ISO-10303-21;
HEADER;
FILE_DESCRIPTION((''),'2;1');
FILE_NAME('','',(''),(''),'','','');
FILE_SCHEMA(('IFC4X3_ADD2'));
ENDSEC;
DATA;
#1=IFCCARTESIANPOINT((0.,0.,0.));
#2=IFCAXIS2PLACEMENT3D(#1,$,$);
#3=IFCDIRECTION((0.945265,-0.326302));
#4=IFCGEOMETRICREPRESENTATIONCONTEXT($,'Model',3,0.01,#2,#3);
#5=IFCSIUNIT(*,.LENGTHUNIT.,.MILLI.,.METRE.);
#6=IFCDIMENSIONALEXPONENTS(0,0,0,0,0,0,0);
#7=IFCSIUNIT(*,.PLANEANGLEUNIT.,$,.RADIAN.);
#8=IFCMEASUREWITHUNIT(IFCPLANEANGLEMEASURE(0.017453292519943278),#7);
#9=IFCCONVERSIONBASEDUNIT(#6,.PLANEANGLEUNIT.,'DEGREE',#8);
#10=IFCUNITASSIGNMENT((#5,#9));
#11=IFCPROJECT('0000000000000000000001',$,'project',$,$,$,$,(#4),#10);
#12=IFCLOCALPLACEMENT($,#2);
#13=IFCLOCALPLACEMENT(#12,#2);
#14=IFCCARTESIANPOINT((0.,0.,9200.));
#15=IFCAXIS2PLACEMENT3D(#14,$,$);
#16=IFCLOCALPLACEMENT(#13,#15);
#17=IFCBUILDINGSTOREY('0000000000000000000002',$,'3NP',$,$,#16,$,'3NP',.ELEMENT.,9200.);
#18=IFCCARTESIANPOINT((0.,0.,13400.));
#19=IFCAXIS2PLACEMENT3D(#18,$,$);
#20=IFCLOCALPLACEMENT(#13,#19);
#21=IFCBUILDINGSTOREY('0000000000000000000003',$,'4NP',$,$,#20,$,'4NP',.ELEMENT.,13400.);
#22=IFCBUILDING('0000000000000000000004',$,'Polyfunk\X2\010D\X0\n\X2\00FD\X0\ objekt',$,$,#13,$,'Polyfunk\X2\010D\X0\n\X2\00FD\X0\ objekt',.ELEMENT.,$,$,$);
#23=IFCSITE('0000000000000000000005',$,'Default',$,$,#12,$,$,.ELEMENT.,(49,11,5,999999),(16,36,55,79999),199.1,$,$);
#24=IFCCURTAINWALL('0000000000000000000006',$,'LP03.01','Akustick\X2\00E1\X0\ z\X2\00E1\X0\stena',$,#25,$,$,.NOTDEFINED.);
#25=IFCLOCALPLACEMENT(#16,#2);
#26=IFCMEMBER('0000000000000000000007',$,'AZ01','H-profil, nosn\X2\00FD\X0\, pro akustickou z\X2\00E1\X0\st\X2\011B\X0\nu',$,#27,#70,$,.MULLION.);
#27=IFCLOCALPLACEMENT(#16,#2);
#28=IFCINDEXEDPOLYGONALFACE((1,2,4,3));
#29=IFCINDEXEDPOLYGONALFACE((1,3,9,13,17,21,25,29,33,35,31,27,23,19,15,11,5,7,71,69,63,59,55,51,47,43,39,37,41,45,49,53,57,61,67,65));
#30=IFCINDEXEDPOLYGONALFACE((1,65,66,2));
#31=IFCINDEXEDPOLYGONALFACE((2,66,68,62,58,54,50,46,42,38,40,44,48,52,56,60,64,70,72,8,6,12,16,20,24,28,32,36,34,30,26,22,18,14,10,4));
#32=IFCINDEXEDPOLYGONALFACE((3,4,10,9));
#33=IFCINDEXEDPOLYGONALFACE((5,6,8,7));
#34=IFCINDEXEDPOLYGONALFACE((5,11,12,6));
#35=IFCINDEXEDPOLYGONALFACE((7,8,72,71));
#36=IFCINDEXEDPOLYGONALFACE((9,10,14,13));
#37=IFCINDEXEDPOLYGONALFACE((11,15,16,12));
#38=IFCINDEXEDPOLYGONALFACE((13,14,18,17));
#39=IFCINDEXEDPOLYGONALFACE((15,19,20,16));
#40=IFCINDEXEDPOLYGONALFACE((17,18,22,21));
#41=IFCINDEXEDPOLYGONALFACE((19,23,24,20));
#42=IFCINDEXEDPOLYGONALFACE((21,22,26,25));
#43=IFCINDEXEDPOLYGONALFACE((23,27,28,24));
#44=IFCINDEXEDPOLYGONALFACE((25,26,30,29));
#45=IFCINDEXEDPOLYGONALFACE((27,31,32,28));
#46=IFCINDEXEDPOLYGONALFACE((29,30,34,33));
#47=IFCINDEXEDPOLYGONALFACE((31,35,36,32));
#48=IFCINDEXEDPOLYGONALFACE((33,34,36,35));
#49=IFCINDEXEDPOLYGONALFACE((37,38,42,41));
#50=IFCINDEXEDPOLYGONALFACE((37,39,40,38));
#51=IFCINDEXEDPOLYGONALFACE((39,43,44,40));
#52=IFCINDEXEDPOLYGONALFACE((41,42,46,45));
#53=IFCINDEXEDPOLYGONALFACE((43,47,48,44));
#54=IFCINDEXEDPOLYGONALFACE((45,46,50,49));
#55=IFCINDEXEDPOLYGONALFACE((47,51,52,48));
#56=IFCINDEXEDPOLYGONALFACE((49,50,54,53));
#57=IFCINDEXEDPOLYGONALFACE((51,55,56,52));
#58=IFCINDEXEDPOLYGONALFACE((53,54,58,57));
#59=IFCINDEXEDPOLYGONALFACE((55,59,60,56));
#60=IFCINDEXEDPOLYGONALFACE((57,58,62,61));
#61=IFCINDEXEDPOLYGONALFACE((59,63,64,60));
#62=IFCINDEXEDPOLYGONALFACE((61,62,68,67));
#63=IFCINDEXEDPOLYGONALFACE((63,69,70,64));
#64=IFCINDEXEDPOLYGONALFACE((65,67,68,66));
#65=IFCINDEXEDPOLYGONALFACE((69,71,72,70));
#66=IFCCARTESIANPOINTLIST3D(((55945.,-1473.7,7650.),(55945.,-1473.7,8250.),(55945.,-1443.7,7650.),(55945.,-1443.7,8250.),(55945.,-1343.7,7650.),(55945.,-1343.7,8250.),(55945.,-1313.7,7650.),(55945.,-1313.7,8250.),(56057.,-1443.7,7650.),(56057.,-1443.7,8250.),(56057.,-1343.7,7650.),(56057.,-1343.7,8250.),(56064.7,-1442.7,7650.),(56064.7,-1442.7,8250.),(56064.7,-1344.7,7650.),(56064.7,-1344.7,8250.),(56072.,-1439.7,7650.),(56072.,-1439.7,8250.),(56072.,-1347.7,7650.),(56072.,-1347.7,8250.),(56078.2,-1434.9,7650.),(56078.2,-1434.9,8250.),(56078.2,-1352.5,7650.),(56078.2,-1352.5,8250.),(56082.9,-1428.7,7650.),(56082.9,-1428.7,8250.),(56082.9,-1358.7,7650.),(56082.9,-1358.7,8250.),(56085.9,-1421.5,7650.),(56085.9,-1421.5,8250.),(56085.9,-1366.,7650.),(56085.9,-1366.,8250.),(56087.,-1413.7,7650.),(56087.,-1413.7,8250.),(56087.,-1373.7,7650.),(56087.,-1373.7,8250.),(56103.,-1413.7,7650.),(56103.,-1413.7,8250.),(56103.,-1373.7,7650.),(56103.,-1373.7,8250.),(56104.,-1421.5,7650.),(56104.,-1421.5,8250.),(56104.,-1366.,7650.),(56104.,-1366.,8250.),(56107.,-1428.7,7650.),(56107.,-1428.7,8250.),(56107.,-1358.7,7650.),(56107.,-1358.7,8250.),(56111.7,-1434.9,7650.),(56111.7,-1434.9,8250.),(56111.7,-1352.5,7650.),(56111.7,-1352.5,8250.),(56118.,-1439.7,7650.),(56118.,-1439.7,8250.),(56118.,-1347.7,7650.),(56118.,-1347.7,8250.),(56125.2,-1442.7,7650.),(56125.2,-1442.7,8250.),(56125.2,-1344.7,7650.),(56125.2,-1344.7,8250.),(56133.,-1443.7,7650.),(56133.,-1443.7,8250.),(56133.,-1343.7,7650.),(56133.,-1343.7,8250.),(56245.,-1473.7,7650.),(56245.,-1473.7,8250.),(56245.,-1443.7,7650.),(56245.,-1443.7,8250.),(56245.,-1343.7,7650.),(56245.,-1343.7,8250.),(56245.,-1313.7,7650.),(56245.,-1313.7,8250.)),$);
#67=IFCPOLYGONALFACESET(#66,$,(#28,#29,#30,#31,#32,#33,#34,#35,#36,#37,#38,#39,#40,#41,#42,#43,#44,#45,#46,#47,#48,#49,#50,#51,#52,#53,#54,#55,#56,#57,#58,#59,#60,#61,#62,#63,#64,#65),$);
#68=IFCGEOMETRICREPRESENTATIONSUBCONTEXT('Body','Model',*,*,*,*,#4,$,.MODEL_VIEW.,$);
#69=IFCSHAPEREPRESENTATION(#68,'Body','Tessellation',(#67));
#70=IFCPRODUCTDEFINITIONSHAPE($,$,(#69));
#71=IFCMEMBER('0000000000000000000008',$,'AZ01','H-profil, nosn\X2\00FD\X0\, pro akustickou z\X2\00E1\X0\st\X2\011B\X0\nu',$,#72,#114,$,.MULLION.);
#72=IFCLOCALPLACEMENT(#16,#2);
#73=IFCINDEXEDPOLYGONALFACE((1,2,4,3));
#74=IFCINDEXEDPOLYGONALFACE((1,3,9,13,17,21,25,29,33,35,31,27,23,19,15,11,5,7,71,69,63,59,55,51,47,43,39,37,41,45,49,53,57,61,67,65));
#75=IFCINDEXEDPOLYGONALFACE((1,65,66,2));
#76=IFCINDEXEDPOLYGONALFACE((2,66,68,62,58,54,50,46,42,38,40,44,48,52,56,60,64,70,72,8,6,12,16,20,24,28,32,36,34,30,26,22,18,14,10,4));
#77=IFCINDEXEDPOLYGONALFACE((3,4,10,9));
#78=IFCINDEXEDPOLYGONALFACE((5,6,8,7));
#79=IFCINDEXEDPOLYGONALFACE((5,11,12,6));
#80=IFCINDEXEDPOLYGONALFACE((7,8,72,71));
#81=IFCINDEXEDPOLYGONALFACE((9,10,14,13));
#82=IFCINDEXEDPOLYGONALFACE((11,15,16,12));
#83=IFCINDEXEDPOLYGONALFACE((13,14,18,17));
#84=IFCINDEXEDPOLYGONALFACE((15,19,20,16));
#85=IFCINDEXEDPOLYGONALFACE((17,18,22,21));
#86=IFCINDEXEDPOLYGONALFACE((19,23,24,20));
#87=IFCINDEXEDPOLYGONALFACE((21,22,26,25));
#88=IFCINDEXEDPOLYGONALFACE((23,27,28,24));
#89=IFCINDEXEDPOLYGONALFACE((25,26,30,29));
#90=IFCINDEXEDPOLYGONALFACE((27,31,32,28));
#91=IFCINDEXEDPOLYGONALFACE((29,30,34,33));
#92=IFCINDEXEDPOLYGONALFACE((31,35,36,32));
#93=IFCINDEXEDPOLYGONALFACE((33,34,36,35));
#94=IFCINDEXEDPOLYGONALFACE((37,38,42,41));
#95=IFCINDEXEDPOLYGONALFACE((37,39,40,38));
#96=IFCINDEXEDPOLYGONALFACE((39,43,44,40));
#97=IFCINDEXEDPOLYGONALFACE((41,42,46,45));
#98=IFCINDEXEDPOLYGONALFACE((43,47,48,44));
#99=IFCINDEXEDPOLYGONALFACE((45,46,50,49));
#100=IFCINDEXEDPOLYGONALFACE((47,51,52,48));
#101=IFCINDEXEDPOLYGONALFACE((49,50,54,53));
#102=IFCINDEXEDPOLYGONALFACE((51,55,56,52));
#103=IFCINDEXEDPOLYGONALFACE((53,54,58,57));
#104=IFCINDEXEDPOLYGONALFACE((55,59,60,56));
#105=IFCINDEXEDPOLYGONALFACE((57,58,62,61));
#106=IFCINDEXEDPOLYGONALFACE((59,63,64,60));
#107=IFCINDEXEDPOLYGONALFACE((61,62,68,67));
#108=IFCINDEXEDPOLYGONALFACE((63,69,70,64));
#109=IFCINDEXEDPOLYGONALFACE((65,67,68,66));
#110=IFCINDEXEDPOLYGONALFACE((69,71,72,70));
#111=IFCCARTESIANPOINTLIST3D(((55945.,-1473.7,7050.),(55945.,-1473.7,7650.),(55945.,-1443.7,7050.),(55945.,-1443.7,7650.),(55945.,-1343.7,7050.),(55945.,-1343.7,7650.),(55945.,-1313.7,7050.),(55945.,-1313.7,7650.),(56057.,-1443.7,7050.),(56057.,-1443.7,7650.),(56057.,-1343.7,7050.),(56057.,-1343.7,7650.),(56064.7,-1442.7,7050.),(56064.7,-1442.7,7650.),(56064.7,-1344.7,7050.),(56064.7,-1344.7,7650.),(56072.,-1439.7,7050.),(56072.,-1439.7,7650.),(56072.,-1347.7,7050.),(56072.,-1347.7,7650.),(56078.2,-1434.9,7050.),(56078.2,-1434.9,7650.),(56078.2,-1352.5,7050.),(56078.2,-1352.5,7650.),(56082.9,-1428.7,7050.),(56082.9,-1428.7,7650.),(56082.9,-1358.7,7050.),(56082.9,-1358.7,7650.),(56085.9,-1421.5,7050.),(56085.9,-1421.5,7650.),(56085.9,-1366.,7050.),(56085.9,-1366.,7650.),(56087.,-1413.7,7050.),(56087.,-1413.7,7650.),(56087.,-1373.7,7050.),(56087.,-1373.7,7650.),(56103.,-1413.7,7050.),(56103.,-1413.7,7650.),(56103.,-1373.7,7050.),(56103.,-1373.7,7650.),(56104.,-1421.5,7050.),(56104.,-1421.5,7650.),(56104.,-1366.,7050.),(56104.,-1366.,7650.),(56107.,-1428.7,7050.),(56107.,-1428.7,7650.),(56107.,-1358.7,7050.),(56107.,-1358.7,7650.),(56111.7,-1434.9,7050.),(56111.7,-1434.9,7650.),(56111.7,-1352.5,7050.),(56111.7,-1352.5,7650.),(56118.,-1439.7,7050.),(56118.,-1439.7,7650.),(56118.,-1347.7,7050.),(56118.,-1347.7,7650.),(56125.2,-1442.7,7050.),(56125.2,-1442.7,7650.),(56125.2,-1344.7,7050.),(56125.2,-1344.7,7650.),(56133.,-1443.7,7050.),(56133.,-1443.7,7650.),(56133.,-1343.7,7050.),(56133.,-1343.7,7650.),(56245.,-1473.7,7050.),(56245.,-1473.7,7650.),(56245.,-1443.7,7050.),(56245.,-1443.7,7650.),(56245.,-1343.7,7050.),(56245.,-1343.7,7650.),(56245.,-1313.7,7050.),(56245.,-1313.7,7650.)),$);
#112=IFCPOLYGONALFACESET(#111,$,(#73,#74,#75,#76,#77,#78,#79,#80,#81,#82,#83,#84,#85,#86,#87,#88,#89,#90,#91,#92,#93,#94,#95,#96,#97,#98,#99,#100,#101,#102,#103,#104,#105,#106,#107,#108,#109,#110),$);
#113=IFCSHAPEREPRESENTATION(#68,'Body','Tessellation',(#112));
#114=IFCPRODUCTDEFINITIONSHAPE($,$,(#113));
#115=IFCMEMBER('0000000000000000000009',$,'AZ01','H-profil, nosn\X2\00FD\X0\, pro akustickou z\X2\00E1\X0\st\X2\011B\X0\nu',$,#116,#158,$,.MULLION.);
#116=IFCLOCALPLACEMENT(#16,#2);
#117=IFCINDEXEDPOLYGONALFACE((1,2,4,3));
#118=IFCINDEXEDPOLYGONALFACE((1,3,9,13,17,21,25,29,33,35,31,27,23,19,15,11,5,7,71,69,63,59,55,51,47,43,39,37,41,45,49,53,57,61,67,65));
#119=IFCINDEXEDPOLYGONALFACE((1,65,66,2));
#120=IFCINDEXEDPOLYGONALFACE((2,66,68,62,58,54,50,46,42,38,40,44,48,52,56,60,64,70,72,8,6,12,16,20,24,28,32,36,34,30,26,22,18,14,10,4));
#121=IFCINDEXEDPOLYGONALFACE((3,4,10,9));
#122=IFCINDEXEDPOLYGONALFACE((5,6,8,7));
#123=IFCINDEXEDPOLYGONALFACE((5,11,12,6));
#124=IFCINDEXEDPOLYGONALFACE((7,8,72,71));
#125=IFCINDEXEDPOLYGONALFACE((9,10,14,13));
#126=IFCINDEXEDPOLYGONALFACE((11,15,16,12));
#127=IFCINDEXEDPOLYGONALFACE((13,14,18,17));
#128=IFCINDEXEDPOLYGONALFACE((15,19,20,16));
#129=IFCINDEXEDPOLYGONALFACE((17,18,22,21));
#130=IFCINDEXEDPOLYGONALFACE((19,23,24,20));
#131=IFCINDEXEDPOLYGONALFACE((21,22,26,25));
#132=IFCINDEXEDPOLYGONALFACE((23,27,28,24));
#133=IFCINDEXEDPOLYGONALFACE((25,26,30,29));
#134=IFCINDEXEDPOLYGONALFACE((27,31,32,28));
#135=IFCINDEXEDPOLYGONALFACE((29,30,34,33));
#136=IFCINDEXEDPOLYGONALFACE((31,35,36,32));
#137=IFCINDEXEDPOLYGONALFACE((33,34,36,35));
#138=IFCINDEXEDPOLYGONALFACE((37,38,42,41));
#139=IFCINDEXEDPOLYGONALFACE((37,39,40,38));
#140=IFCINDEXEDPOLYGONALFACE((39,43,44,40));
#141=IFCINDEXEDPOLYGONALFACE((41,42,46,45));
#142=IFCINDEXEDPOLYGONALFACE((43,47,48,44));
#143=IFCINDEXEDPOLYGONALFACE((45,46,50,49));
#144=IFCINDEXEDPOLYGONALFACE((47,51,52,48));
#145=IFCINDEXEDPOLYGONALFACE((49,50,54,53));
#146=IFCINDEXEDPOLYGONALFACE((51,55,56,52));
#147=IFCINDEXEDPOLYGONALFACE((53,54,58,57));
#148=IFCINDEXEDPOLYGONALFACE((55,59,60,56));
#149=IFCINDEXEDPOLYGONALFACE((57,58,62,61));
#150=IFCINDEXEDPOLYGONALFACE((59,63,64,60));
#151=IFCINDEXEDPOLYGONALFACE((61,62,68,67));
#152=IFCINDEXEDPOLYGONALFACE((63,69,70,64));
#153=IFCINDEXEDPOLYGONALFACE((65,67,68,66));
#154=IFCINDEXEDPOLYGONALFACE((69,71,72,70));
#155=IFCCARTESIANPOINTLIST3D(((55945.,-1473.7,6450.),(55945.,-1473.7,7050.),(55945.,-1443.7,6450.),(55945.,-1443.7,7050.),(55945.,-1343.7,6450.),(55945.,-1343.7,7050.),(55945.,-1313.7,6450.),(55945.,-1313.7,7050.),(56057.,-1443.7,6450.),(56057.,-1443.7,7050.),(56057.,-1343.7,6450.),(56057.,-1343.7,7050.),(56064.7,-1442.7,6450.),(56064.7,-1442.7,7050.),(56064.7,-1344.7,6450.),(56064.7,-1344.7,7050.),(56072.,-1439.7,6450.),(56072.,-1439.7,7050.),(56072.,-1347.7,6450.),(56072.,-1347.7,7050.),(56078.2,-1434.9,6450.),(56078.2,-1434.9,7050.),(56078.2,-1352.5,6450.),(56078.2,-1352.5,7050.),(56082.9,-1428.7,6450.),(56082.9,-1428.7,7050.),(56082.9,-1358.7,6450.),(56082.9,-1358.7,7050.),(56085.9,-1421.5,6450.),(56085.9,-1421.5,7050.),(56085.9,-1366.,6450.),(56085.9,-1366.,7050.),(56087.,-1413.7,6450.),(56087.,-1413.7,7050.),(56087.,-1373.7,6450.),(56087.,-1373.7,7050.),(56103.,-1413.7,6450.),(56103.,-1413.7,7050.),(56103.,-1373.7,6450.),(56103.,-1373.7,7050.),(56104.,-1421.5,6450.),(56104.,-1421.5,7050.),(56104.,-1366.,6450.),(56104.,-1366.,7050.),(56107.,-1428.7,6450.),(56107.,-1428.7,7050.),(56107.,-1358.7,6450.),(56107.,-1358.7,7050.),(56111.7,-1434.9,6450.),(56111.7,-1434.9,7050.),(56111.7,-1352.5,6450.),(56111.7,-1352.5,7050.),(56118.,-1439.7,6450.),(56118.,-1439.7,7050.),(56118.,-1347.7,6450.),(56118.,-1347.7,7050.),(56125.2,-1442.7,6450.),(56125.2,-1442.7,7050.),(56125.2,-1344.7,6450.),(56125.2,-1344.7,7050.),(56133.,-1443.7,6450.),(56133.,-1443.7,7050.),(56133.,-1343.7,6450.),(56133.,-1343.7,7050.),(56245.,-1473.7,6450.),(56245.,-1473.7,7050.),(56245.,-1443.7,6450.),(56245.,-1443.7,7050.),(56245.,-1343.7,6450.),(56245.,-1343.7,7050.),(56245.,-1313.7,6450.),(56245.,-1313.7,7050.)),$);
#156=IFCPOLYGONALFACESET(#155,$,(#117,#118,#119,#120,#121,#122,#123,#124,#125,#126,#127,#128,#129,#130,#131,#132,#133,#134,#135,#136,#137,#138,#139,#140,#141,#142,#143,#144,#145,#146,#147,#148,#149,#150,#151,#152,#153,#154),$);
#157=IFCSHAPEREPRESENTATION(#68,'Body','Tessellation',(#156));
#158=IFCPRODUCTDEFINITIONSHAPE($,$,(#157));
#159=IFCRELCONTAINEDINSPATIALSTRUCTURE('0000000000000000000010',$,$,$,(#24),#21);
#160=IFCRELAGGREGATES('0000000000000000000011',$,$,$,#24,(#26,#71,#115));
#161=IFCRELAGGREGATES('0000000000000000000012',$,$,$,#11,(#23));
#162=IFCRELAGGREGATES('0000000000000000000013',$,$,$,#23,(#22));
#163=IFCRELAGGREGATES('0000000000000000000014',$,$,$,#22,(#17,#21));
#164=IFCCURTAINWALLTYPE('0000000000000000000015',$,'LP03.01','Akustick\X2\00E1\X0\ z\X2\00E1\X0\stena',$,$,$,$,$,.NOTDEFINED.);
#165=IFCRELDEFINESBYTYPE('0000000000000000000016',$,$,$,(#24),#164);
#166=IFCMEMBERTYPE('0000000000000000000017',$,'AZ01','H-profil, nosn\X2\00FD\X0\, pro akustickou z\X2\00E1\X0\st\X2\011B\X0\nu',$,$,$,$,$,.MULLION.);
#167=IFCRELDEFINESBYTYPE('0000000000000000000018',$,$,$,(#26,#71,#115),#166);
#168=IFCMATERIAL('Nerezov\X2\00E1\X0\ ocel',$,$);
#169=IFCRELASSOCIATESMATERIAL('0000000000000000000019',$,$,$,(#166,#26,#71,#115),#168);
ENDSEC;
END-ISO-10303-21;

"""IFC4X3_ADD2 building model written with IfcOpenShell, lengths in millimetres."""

from ifc_helpers import new_model, entity, si_unit, converted_unit, direction, frame, frame_2d, origin, place, context, subcontext, project, spatial, polyline, circle_curve, parameter, trimmed, segment, composite_curve, outline, extrude, source, transform, mapped, material, material_profile, profile_set, profile_usage, type_object, element, aggregate, save


model = new_model("IFC4X3_ADD2")

# Units and contexts
model_context = context("Model", 3, precision=0.01, world=origin(), true_north=direction((0.945265, -0.326302)))
body_context = subcontext(model_context, "Body", "Model", "MODEL_VIEW")
ifc_project = project(units=[si_unit("LENGTHUNIT", "METRE", prefix="MILLI"), converted_unit("PLANEANGLEUNIT", "DEGREE", entity("IfcPlaneAngleMeasure", 0.017453292519943278), si_unit("PLANEANGLEUNIT", "RADIAN"), dimensions=[0, 0, 0, 0, 0, 0, 0])], contexts=[model_context])

# Site, building, storey
site_placement = place(None, origin())
site = spatial("IfcSite", under=ifc_project, at=site_placement, Name="Default", CompositionType="ELEMENT", RefLatitude=(49, 11, 5, 999999), RefLongitude=(16, 36, 55, 79999), RefElevation=199.1)
building_placement = place(site_placement, origin())
building = spatial("IfcBuilding", under=site, at=building_placement, Name="Polyfunkčný objekt", LongName="Polyfunkčný objekt", CompositionType="ELEMENT")
storey_1_placement = place(building_placement, frame((0.0, 0.0, 9200.0)))
storey_1 = spatial("IfcBuildingStorey", under=building, at=storey_1_placement, Name="3NP", LongName="3NP", CompositionType="ELEMENT", Elevation=9200.0)

# Shared definitions
storey_2_placement = place(building_placement, frame((0.0, 0.0, 13400.0)))
storey_2 = spatial("IfcBuildingStorey", under=building, at=storey_2_placement, Name="4NP", LongName="4NP", CompositionType="ELEMENT", Elevation=13400.0)

# Curtain wall, members
curtain_wall_type_1 = type_object("IfcCurtainWallType", Name="LP03.01", Description="Akustická zástena", PredefinedType="NOTDEFINED")
curtain_wall_1_placement = place(storey_2_placement, frame((0.0, 0.0, -13400.0)))
curtain_wall_1 = element("IfcCurtainWall", 1, at=curtain_wall_1_placement, inside=storey_2, type_object=curtain_wall_type_1, Name="LP03.01", Description="Akustická zástena", PredefinedType="NOTDEFINED")
ifc_material_1 = material(Name="Nerezová ocel")
ifc_material_profile_1 = material_profile(ifc_material_1, outline(composite_curve([segment(polyline([(50.0, -150.0), (80.0, -150.0)]), True, "CONTINUOUS"), segment(polyline([(80.0, -150.0), (80.0, 150.0)]), True, "CONTINUOUS"), segment(polyline([(80.0, 150.0), (50.0, 150.0)]), True, "CONTINUOUS"), segment(polyline([(50.0, 150.0), (50.0, 38.0)]), True, "CONTINUOUS"), segment(trimmed(circle_curve(frame_2d((20.0, 38.0), x_axis=(0.0, 1.0)), 30.0), [parameter(180.0)], [parameter(270.0)], True, "PARAMETER"), False, "CONTINUOUS"), segment(polyline([(20.0, 8.0), (-20.0, 8.0)]), True, "CONTINUOUS"), segment(trimmed(circle_curve(frame_2d((-20.0, 38.0), x_axis=(0.0, 1.0)), 30.0), [parameter(90.0)], [parameter(180.0)], True, "PARAMETER"), False, "CONTINUOUS"), segment(polyline([(-50.0, 38.0), (-50.0, 150.0)]), True, "CONTINUOUS"), segment(polyline([(-50.0, 150.0), (-80.0, 150.0)]), True, "CONTINUOUS"), segment(polyline([(-80.0, 150.0), (-80.0, -150.0)]), True, "CONTINUOUS"), segment(polyline([(-80.0, -150.0), (-50.0, -150.0)]), True, "CONTINUOUS"), segment(polyline([(-50.0, -150.0), (-50.0, -38.0)]), True, "CONTINUOUS"), segment(trimmed(circle_curve(frame_2d((-20.0, -38.0), x_axis=(0.0, 1.0)), 30.0), [parameter(0.0)], [parameter(90.0)], True, "PARAMETER"), False, "CONTINUOUS"), segment(polyline([(-20.0, -8.0), (20.0, -8.0)]), True, "CONTINUOUS"), segment(trimmed(circle_curve(frame_2d((20.0, -38.0), x_axis=(0.0, 1.0)), 30.0), [parameter(270.0)], [parameter(0.0)], True, "PARAMETER"), False, "CONTINUOUS"), segment(polyline([(50.0, -38.0), (50.0, -150.0)]), True, "CONTINUOUS")], self_intersect=False)), Name="Profil zástena")
ifc_profile_set_1 = profile_set([ifc_material_profile_1], Name="Profil zástena")
ifc_profile_usage_1 = profile_usage(ifc_profile_set_1)
member_type_1 = type_object("IfcMemberType", Name="AZ01", Description="H-profil, nosný, pro akustickou zástěnu", PredefinedType="MULLION", material=ifc_profile_set_1)
shared_shape_1 = source(origin(), body_context, "Body", "SweptSolid", [
    extrude(outline(composite_curve([segment(polyline([(50.0, -150.0), (80.0, -150.0)]), True, "CONTINUOUS"), segment(polyline([(80.0, -150.0), (80.0, 150.0)]), True, "CONTINUOUS"), segment(polyline([(80.0, 150.0), (50.0, 150.0)]), True, "CONTINUOUS"), segment(polyline([(50.0, 150.0), (50.0, 38.0)]), True, "CONTINUOUS"), segment(trimmed(circle_curve(frame_2d((20.0, 38.0), x_axis=(0.0, 1.0)), 30.0), [parameter(180.0)], [parameter(270.0)], True, "PARAMETER"), False, "CONTINUOUS"), segment(polyline([(20.0, 8.0), (-20.0, 8.0)]), True, "CONTINUOUS"), segment(trimmed(circle_curve(frame_2d((-20.0, 38.0), x_axis=(0.0, 1.0)), 30.0), [parameter(90.0)], [parameter(180.0)], True, "PARAMETER"), False, "CONTINUOUS"), segment(polyline([(-50.0, 38.0), (-50.0, 150.0)]), True, "CONTINUOUS"), segment(polyline([(-50.0, 150.0), (-80.0, 150.0)]), True, "CONTINUOUS"), segment(polyline([(-80.0, 150.0), (-80.0, -150.0)]), True, "CONTINUOUS"), segment(polyline([(-80.0, -150.0), (-50.0, -150.0)]), True, "CONTINUOUS"), segment(polyline([(-50.0, -150.0), (-50.0, -38.0)]), True, "CONTINUOUS"), segment(trimmed(circle_curve(frame_2d((-20.0, -38.0), x_axis=(0.0, 1.0)), 30.0), [parameter(0.0)], [parameter(90.0)], True, "PARAMETER"), False, "CONTINUOUS"), segment(polyline([(-20.0, -8.0), (20.0, -8.0)]), True, "CONTINUOUS"), segment(trimmed(circle_curve(frame_2d((20.0, -38.0), x_axis=(0.0, 1.0)), 30.0), [parameter(270.0)], [parameter(0.0)], True, "PARAMETER"), False, "CONTINUOUS"), segment(polyline([(50.0, -38.0), (50.0, -150.0)]), True, "CONTINUOUS")], self_intersect=False)), frame((-150.0, 0.0, -600.0), z_axis=(0.0, 0.0, 1.0), x_axis=(0.0, -1.0, 0.0)), (0.0, 0.0, 1.0), 600.0),
])
member_1_placement = place(curtain_wall_1_placement, frame((56245.0, -1393.7, 16850.0), z_axis=(0.0, 0.0, -1.0), x_axis=(1.0, 0.0, 0.0)))
member_1 = element("IfcMember", 2, at=member_1_placement, type_object=member_type_1, material=ifc_profile_usage_1, Name="AZ01", Description="H-profil, nosný, pro akustickou zástěnu", PredefinedType="MULLION", context=body_context, shape_type="MappedRepresentation", body=[
    mapped(shared_shape_1, transform((0.0, 0.0, 0.0), scale=1.0)),
])
member_2_placement = place(curtain_wall_1_placement, frame((56245.0, -1393.7, 16250.0), z_axis=(0.0, 0.0, -1.0), x_axis=(1.0, 0.0, 0.0)))
member_2 = element("IfcMember", 3, at=member_2_placement, type_object=member_type_1, material=ifc_profile_usage_1, Name="AZ01", Description="H-profil, nosný, pro akustickou zástěnu", PredefinedType="MULLION", context=body_context, shape_type="MappedRepresentation", body=[
    mapped(shared_shape_1, transform((0.0, 0.0, 0.0), scale=1.0)),
])
member_3_placement = place(curtain_wall_1_placement, frame((56245.0, -1393.7, 15650.0), z_axis=(0.0, 0.0, -1.0), x_axis=(1.0, 0.0, 0.0)))
member_3 = element("IfcMember", 4, at=member_3_placement, type_object=member_type_1, material=ifc_profile_usage_1, Name="AZ01", Description="H-profil, nosný, pro akustickou zástěnu", PredefinedType="MULLION", context=body_context, shape_type="MappedRepresentation", body=[
    mapped(shared_shape_1, transform((0.0, 0.0, 0.0), scale=1.0)),
])
aggregate(curtain_wall_1, [member_1, member_2, member_3])

save(model, "model.ifc")
